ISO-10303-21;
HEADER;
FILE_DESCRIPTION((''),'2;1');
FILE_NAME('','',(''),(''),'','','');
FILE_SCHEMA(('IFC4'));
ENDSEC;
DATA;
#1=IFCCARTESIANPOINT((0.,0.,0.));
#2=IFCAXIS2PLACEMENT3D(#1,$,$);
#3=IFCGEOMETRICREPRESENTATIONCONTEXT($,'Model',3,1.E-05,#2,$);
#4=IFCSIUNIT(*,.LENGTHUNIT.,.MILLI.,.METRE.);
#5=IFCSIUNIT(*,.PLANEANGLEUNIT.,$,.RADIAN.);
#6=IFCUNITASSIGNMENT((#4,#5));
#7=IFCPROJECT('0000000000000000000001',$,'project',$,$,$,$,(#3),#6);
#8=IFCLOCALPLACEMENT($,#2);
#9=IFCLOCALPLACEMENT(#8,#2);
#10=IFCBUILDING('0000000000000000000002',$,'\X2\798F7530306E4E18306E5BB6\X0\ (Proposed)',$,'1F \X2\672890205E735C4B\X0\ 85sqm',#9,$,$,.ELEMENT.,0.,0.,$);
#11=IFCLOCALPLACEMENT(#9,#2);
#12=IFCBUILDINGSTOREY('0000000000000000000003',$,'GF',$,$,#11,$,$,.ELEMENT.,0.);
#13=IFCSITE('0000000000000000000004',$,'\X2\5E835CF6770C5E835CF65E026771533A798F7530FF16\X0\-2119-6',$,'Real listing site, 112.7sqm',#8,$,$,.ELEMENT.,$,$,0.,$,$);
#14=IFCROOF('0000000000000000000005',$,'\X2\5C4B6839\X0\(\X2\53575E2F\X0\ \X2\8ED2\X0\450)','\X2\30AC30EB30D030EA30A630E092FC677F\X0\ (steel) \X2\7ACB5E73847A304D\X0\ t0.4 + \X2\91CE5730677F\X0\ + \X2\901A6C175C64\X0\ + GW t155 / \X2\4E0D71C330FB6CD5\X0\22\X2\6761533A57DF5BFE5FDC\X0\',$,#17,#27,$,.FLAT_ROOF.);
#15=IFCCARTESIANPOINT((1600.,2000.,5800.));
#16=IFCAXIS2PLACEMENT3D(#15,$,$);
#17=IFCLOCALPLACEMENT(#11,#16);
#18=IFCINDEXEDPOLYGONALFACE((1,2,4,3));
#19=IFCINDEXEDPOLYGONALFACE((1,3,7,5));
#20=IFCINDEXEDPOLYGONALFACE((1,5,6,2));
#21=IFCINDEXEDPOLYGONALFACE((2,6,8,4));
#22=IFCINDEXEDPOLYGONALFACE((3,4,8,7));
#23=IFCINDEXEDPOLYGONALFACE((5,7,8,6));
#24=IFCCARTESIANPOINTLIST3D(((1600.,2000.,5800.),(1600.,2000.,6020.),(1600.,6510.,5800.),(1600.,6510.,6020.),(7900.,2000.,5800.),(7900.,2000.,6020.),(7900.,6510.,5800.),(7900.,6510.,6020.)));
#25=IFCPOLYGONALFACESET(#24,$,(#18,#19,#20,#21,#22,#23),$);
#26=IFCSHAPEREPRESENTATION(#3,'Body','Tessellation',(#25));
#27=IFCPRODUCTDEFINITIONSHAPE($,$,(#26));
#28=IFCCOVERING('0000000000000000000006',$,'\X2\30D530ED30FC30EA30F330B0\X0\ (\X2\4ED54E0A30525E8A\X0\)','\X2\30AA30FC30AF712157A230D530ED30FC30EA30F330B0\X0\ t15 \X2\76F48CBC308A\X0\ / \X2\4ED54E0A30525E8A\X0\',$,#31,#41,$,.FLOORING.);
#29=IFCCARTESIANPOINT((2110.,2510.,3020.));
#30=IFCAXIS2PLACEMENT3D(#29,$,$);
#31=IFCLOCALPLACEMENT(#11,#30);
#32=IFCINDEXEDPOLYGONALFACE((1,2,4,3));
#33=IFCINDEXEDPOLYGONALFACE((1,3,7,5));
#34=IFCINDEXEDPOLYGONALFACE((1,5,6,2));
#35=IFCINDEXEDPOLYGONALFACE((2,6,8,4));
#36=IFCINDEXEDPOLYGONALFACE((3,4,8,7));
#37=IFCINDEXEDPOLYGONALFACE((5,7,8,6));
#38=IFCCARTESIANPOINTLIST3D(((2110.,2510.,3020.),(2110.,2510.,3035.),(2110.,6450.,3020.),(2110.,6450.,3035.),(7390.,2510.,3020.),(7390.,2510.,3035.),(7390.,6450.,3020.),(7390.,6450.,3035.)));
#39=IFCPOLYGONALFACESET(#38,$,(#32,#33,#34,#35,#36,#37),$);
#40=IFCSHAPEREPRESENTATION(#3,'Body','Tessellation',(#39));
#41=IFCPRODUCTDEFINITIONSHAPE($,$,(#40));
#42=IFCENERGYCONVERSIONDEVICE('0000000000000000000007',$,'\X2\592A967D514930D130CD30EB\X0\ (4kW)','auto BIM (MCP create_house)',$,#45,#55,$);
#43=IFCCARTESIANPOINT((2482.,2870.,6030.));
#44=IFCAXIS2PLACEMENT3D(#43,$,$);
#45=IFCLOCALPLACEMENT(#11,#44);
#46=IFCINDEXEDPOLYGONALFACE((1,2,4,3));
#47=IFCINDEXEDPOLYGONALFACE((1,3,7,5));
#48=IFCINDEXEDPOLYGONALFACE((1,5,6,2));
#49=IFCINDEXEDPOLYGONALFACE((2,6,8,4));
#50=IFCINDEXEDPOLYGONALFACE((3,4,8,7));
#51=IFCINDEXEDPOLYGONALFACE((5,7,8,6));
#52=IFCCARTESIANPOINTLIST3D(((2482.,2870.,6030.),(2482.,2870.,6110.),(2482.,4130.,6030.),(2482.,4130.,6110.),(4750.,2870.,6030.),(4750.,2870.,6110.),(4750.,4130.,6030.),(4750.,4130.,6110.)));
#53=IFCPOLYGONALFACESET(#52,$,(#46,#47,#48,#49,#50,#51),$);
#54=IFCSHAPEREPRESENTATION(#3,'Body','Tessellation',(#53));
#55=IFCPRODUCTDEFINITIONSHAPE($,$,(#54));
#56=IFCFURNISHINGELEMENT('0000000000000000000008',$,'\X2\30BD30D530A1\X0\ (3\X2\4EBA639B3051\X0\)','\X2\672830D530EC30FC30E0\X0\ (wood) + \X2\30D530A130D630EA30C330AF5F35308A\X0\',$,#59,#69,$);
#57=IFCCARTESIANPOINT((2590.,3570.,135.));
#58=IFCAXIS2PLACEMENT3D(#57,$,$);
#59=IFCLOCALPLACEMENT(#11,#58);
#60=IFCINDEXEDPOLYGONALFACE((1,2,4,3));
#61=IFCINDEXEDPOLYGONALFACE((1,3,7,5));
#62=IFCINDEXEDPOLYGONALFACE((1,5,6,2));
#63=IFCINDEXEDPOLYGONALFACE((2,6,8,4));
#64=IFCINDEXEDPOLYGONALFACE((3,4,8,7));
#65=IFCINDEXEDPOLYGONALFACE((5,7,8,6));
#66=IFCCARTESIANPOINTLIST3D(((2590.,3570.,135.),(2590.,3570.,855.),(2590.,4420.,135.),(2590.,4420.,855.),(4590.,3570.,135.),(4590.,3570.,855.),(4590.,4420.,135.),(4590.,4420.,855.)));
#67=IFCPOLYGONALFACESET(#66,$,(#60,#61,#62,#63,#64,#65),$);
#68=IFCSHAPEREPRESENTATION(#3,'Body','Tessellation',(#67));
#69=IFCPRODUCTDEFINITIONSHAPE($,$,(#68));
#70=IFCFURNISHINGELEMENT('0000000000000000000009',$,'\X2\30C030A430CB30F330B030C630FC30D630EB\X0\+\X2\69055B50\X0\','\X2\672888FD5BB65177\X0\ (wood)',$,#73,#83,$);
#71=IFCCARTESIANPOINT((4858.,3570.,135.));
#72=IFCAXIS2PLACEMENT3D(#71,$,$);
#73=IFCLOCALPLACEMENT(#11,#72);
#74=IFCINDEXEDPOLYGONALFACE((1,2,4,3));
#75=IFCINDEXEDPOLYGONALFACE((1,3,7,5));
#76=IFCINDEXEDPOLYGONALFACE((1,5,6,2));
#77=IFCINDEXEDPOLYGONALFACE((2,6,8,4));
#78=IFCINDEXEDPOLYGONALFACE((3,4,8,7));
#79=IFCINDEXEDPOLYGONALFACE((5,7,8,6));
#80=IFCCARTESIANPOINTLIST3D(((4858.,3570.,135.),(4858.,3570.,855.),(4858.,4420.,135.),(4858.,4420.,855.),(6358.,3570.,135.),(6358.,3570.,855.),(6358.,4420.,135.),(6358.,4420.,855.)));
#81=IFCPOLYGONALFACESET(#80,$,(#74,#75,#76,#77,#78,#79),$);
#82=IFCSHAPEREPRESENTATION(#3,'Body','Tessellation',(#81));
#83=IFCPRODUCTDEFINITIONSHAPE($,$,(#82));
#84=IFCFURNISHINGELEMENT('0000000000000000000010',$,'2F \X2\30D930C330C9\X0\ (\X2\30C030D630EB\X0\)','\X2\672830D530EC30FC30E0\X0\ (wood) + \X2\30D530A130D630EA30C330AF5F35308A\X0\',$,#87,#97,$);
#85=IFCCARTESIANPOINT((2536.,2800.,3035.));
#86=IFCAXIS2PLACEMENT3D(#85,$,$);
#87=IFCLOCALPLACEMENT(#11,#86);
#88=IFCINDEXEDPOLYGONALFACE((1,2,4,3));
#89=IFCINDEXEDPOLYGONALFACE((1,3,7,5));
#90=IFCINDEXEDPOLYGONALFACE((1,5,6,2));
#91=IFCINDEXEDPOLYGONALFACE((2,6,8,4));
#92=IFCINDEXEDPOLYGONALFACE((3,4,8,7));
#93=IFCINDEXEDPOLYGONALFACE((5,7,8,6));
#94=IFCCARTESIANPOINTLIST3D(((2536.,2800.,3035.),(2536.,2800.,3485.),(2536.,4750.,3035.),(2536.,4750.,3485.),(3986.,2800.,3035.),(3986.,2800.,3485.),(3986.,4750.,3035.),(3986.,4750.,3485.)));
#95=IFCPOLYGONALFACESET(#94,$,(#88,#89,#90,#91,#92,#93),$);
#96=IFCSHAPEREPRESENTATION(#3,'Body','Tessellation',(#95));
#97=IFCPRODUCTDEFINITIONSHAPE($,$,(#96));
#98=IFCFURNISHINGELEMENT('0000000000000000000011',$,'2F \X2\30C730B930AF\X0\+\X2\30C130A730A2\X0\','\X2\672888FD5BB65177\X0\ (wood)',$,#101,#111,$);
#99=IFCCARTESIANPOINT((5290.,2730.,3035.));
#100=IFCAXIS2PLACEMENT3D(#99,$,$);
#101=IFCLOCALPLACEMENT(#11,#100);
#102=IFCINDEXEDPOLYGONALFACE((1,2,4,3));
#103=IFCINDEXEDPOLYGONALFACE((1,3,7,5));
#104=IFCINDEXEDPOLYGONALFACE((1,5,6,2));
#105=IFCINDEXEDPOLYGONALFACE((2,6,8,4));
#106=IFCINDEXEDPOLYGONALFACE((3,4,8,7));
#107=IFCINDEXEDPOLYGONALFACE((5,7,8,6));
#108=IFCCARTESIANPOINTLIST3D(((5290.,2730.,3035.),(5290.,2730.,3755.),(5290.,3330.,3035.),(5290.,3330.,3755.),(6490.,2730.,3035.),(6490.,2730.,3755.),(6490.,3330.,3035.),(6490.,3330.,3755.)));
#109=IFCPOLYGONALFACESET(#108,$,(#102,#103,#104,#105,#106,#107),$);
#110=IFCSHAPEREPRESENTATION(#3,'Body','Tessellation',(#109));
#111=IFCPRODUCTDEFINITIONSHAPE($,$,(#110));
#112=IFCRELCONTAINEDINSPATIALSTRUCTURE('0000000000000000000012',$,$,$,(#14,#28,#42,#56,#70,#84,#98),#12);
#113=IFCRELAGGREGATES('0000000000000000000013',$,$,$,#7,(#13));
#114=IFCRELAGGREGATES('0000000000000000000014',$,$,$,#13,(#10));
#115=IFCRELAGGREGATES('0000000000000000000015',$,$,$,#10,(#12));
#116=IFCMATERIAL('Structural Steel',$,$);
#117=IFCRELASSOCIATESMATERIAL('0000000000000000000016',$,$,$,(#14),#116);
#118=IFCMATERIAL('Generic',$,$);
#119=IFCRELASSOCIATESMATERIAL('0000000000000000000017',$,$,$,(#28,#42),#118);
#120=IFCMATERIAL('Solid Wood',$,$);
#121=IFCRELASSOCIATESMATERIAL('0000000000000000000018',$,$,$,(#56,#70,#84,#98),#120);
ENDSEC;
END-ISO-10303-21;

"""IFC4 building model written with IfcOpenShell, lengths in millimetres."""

from ifc_helpers import new_model, si_unit, frame, frame_2d, origin, place, context, project, spatial, rectangle, extrude, material, element, save


model = new_model("IFC4")

# Units and contexts
model_context = context("Model", 3, precision=1e-05, world=origin())
ifc_project = project(units=[si_unit("LENGTHUNIT", "METRE", prefix="MILLI"), si_unit("PLANEANGLEUNIT", "RADIAN")], contexts=[model_context])

# Site, building, storey
site_placement = place(None, origin())
site = spatial("IfcSite", under=ifc_project, at=site_placement, Name="広島県広島市東区福田６-2119-6", ObjectType="Real listing site, 112.7sqm", CompositionType="ELEMENT", RefElevation=0.0)
building_placement = place(site_placement, origin())
building = spatial("IfcBuilding", under=site, at=building_placement, Name="福田の丘の家 (Proposed)", ObjectType="1F 木造平屋 85sqm", CompositionType="ELEMENT", ElevationOfRefHeight=0.0, ElevationOfTerrain=0.0)
storey_placement = place(building_placement, origin())
storey = spatial("IfcBuildingStorey", under=building, at=storey_placement, Name="GF", CompositionType="ELEMENT", Elevation=0.0)

# Shared definitions
ifc_material_1 = material(Name="Solid Wood")

# Shared definitions
ifc_material_2 = material(Name="Generic")

# Roof
ifc_material_3 = material(Name="Structural Steel")
for number, where, name in (
    (1, (1600.0, 2000.0, 5800.0), "屋根(南帯 軒450)"),
):
    element("IfcRoof", number, at=place(storey_placement, frame(where)), inside=storey, material=ifc_material_3, Name=name, Description="ガルバリウム鋼板 (steel) 立平葺き t0.4 + 野地板 + 通気層 + GW t155 / 不燃・法22条区域対応", PredefinedType="FLAT_ROOF", context=model_context, shape_type="SweptSolid", body=[
        extrude(rectangle(XDim=6300.0, YDim=4510.0, at=frame_2d((3150.0, 2255.0))), frame((1600.0, 2000.0, 5800.0)), (0.0, 0.0, 1.0), 220.0),
    ])

# Covering
covering_placement = place(storey_placement, frame((2110.0, 2510.0, 3020.0)))
element("IfcCovering", 2, at=covering_placement, inside=storey, material=ifc_material_2, Name="フローリング (仕上げ床)", Description="オーク無垢フローリング t15 直貼り / 仕上げ床", PredefinedType="FLOORING", context=model_context, shape_type="SweptSolid", body=[
    extrude(rectangle(XDim=5280.0, YDim=3940.0, at=frame_2d((2640.0, 1970.0))), frame((2110.0, 2510.0, 3020.0)), (0.0, 0.0, 1.0), 15.0),
])

# Energy conversion device
energy_conversion_device_placement = place(storey_placement, frame((2482.0, 2870.0, 6030.0)))
element("IfcEnergyConversionDevice", 3, at=energy_conversion_device_placement, inside=storey, material=ifc_material_2, Name="太陽光パネル (4kW)", Description="auto BIM (MCP create_house)", context=model_context, shape_type="SweptSolid", body=[
    extrude(rectangle(XDim=2268.0, YDim=1260.0, at=frame_2d((1134.0, 630.0))), frame((2482.0, 2870.0, 6030.0)), (0.0, 0.0, 1.0), 80.0),
])

# Furnishing elements
furnishing_1_placement = place(storey_placement, frame((2590.0, 3570.0, 135.0)))
element("IfcFurnishingElement", 4, at=furnishing_1_placement, inside=storey, material=ifc_material_1, Name="ソファ (3人掛け)", Description="木フレーム (wood) + ファブリック張り", context=model_context, shape_type="SweptSolid", body=[
    extrude(rectangle(XDim=2000.0, YDim=850.0, at=frame_2d((1000.0, 425.0))), frame((2590.0, 3570.0, 135.0)), (0.0, 0.0, 1.0), 720.0),
])
furnishing_2_placement = place(storey_placement, frame((4858.0, 3570.0, 135.0)))
element("IfcFurnishingElement", 5, at=furnishing_2_placement, inside=storey, material=ifc_material_1, Name="ダイニングテーブル+椅子", Description="木製家具 (wood)", context=model_context, shape_type="SweptSolid", body=[
    extrude(rectangle(XDim=1500.0, YDim=850.0, at=frame_2d((750.0, 425.0))), frame((4858.0, 3570.0, 135.0)), (0.0, 0.0, 1.0), 720.0),
])
furnishing_3_placement = place(storey_placement, frame((2536.0, 2800.0, 3035.0)))
element("IfcFurnishingElement", 6, at=furnishing_3_placement, inside=storey, material=ifc_material_1, Name="2F ベッド (ダブル)", Description="木フレーム (wood) + ファブリック張り", context=model_context, shape_type="SweptSolid", body=[
    extrude(rectangle(XDim=1450.0, YDim=1950.0, at=frame_2d((725.0, 975.0))), frame((2536.0, 2800.0, 3035.0)), (0.0, 0.0, 1.0), 450.0),
])
furnishing_4_placement = place(storey_placement, frame((5290.0, 2730.0, 3035.0)))
element("IfcFurnishingElement", 7, at=furnishing_4_placement, inside=storey, material=ifc_material_1, Name="2F デスク+チェア", Description="木製家具 (wood)", context=model_context, shape_type="SweptSolid", body=[
    extrude(rectangle(XDim=1200.0, YDim=600.0, at=frame_2d((600.0, 300.0))), frame((5290.0, 2730.0, 3035.0)), (0.0, 0.0, 1.0), 720.0),
])

save(model, "model.ifc")
